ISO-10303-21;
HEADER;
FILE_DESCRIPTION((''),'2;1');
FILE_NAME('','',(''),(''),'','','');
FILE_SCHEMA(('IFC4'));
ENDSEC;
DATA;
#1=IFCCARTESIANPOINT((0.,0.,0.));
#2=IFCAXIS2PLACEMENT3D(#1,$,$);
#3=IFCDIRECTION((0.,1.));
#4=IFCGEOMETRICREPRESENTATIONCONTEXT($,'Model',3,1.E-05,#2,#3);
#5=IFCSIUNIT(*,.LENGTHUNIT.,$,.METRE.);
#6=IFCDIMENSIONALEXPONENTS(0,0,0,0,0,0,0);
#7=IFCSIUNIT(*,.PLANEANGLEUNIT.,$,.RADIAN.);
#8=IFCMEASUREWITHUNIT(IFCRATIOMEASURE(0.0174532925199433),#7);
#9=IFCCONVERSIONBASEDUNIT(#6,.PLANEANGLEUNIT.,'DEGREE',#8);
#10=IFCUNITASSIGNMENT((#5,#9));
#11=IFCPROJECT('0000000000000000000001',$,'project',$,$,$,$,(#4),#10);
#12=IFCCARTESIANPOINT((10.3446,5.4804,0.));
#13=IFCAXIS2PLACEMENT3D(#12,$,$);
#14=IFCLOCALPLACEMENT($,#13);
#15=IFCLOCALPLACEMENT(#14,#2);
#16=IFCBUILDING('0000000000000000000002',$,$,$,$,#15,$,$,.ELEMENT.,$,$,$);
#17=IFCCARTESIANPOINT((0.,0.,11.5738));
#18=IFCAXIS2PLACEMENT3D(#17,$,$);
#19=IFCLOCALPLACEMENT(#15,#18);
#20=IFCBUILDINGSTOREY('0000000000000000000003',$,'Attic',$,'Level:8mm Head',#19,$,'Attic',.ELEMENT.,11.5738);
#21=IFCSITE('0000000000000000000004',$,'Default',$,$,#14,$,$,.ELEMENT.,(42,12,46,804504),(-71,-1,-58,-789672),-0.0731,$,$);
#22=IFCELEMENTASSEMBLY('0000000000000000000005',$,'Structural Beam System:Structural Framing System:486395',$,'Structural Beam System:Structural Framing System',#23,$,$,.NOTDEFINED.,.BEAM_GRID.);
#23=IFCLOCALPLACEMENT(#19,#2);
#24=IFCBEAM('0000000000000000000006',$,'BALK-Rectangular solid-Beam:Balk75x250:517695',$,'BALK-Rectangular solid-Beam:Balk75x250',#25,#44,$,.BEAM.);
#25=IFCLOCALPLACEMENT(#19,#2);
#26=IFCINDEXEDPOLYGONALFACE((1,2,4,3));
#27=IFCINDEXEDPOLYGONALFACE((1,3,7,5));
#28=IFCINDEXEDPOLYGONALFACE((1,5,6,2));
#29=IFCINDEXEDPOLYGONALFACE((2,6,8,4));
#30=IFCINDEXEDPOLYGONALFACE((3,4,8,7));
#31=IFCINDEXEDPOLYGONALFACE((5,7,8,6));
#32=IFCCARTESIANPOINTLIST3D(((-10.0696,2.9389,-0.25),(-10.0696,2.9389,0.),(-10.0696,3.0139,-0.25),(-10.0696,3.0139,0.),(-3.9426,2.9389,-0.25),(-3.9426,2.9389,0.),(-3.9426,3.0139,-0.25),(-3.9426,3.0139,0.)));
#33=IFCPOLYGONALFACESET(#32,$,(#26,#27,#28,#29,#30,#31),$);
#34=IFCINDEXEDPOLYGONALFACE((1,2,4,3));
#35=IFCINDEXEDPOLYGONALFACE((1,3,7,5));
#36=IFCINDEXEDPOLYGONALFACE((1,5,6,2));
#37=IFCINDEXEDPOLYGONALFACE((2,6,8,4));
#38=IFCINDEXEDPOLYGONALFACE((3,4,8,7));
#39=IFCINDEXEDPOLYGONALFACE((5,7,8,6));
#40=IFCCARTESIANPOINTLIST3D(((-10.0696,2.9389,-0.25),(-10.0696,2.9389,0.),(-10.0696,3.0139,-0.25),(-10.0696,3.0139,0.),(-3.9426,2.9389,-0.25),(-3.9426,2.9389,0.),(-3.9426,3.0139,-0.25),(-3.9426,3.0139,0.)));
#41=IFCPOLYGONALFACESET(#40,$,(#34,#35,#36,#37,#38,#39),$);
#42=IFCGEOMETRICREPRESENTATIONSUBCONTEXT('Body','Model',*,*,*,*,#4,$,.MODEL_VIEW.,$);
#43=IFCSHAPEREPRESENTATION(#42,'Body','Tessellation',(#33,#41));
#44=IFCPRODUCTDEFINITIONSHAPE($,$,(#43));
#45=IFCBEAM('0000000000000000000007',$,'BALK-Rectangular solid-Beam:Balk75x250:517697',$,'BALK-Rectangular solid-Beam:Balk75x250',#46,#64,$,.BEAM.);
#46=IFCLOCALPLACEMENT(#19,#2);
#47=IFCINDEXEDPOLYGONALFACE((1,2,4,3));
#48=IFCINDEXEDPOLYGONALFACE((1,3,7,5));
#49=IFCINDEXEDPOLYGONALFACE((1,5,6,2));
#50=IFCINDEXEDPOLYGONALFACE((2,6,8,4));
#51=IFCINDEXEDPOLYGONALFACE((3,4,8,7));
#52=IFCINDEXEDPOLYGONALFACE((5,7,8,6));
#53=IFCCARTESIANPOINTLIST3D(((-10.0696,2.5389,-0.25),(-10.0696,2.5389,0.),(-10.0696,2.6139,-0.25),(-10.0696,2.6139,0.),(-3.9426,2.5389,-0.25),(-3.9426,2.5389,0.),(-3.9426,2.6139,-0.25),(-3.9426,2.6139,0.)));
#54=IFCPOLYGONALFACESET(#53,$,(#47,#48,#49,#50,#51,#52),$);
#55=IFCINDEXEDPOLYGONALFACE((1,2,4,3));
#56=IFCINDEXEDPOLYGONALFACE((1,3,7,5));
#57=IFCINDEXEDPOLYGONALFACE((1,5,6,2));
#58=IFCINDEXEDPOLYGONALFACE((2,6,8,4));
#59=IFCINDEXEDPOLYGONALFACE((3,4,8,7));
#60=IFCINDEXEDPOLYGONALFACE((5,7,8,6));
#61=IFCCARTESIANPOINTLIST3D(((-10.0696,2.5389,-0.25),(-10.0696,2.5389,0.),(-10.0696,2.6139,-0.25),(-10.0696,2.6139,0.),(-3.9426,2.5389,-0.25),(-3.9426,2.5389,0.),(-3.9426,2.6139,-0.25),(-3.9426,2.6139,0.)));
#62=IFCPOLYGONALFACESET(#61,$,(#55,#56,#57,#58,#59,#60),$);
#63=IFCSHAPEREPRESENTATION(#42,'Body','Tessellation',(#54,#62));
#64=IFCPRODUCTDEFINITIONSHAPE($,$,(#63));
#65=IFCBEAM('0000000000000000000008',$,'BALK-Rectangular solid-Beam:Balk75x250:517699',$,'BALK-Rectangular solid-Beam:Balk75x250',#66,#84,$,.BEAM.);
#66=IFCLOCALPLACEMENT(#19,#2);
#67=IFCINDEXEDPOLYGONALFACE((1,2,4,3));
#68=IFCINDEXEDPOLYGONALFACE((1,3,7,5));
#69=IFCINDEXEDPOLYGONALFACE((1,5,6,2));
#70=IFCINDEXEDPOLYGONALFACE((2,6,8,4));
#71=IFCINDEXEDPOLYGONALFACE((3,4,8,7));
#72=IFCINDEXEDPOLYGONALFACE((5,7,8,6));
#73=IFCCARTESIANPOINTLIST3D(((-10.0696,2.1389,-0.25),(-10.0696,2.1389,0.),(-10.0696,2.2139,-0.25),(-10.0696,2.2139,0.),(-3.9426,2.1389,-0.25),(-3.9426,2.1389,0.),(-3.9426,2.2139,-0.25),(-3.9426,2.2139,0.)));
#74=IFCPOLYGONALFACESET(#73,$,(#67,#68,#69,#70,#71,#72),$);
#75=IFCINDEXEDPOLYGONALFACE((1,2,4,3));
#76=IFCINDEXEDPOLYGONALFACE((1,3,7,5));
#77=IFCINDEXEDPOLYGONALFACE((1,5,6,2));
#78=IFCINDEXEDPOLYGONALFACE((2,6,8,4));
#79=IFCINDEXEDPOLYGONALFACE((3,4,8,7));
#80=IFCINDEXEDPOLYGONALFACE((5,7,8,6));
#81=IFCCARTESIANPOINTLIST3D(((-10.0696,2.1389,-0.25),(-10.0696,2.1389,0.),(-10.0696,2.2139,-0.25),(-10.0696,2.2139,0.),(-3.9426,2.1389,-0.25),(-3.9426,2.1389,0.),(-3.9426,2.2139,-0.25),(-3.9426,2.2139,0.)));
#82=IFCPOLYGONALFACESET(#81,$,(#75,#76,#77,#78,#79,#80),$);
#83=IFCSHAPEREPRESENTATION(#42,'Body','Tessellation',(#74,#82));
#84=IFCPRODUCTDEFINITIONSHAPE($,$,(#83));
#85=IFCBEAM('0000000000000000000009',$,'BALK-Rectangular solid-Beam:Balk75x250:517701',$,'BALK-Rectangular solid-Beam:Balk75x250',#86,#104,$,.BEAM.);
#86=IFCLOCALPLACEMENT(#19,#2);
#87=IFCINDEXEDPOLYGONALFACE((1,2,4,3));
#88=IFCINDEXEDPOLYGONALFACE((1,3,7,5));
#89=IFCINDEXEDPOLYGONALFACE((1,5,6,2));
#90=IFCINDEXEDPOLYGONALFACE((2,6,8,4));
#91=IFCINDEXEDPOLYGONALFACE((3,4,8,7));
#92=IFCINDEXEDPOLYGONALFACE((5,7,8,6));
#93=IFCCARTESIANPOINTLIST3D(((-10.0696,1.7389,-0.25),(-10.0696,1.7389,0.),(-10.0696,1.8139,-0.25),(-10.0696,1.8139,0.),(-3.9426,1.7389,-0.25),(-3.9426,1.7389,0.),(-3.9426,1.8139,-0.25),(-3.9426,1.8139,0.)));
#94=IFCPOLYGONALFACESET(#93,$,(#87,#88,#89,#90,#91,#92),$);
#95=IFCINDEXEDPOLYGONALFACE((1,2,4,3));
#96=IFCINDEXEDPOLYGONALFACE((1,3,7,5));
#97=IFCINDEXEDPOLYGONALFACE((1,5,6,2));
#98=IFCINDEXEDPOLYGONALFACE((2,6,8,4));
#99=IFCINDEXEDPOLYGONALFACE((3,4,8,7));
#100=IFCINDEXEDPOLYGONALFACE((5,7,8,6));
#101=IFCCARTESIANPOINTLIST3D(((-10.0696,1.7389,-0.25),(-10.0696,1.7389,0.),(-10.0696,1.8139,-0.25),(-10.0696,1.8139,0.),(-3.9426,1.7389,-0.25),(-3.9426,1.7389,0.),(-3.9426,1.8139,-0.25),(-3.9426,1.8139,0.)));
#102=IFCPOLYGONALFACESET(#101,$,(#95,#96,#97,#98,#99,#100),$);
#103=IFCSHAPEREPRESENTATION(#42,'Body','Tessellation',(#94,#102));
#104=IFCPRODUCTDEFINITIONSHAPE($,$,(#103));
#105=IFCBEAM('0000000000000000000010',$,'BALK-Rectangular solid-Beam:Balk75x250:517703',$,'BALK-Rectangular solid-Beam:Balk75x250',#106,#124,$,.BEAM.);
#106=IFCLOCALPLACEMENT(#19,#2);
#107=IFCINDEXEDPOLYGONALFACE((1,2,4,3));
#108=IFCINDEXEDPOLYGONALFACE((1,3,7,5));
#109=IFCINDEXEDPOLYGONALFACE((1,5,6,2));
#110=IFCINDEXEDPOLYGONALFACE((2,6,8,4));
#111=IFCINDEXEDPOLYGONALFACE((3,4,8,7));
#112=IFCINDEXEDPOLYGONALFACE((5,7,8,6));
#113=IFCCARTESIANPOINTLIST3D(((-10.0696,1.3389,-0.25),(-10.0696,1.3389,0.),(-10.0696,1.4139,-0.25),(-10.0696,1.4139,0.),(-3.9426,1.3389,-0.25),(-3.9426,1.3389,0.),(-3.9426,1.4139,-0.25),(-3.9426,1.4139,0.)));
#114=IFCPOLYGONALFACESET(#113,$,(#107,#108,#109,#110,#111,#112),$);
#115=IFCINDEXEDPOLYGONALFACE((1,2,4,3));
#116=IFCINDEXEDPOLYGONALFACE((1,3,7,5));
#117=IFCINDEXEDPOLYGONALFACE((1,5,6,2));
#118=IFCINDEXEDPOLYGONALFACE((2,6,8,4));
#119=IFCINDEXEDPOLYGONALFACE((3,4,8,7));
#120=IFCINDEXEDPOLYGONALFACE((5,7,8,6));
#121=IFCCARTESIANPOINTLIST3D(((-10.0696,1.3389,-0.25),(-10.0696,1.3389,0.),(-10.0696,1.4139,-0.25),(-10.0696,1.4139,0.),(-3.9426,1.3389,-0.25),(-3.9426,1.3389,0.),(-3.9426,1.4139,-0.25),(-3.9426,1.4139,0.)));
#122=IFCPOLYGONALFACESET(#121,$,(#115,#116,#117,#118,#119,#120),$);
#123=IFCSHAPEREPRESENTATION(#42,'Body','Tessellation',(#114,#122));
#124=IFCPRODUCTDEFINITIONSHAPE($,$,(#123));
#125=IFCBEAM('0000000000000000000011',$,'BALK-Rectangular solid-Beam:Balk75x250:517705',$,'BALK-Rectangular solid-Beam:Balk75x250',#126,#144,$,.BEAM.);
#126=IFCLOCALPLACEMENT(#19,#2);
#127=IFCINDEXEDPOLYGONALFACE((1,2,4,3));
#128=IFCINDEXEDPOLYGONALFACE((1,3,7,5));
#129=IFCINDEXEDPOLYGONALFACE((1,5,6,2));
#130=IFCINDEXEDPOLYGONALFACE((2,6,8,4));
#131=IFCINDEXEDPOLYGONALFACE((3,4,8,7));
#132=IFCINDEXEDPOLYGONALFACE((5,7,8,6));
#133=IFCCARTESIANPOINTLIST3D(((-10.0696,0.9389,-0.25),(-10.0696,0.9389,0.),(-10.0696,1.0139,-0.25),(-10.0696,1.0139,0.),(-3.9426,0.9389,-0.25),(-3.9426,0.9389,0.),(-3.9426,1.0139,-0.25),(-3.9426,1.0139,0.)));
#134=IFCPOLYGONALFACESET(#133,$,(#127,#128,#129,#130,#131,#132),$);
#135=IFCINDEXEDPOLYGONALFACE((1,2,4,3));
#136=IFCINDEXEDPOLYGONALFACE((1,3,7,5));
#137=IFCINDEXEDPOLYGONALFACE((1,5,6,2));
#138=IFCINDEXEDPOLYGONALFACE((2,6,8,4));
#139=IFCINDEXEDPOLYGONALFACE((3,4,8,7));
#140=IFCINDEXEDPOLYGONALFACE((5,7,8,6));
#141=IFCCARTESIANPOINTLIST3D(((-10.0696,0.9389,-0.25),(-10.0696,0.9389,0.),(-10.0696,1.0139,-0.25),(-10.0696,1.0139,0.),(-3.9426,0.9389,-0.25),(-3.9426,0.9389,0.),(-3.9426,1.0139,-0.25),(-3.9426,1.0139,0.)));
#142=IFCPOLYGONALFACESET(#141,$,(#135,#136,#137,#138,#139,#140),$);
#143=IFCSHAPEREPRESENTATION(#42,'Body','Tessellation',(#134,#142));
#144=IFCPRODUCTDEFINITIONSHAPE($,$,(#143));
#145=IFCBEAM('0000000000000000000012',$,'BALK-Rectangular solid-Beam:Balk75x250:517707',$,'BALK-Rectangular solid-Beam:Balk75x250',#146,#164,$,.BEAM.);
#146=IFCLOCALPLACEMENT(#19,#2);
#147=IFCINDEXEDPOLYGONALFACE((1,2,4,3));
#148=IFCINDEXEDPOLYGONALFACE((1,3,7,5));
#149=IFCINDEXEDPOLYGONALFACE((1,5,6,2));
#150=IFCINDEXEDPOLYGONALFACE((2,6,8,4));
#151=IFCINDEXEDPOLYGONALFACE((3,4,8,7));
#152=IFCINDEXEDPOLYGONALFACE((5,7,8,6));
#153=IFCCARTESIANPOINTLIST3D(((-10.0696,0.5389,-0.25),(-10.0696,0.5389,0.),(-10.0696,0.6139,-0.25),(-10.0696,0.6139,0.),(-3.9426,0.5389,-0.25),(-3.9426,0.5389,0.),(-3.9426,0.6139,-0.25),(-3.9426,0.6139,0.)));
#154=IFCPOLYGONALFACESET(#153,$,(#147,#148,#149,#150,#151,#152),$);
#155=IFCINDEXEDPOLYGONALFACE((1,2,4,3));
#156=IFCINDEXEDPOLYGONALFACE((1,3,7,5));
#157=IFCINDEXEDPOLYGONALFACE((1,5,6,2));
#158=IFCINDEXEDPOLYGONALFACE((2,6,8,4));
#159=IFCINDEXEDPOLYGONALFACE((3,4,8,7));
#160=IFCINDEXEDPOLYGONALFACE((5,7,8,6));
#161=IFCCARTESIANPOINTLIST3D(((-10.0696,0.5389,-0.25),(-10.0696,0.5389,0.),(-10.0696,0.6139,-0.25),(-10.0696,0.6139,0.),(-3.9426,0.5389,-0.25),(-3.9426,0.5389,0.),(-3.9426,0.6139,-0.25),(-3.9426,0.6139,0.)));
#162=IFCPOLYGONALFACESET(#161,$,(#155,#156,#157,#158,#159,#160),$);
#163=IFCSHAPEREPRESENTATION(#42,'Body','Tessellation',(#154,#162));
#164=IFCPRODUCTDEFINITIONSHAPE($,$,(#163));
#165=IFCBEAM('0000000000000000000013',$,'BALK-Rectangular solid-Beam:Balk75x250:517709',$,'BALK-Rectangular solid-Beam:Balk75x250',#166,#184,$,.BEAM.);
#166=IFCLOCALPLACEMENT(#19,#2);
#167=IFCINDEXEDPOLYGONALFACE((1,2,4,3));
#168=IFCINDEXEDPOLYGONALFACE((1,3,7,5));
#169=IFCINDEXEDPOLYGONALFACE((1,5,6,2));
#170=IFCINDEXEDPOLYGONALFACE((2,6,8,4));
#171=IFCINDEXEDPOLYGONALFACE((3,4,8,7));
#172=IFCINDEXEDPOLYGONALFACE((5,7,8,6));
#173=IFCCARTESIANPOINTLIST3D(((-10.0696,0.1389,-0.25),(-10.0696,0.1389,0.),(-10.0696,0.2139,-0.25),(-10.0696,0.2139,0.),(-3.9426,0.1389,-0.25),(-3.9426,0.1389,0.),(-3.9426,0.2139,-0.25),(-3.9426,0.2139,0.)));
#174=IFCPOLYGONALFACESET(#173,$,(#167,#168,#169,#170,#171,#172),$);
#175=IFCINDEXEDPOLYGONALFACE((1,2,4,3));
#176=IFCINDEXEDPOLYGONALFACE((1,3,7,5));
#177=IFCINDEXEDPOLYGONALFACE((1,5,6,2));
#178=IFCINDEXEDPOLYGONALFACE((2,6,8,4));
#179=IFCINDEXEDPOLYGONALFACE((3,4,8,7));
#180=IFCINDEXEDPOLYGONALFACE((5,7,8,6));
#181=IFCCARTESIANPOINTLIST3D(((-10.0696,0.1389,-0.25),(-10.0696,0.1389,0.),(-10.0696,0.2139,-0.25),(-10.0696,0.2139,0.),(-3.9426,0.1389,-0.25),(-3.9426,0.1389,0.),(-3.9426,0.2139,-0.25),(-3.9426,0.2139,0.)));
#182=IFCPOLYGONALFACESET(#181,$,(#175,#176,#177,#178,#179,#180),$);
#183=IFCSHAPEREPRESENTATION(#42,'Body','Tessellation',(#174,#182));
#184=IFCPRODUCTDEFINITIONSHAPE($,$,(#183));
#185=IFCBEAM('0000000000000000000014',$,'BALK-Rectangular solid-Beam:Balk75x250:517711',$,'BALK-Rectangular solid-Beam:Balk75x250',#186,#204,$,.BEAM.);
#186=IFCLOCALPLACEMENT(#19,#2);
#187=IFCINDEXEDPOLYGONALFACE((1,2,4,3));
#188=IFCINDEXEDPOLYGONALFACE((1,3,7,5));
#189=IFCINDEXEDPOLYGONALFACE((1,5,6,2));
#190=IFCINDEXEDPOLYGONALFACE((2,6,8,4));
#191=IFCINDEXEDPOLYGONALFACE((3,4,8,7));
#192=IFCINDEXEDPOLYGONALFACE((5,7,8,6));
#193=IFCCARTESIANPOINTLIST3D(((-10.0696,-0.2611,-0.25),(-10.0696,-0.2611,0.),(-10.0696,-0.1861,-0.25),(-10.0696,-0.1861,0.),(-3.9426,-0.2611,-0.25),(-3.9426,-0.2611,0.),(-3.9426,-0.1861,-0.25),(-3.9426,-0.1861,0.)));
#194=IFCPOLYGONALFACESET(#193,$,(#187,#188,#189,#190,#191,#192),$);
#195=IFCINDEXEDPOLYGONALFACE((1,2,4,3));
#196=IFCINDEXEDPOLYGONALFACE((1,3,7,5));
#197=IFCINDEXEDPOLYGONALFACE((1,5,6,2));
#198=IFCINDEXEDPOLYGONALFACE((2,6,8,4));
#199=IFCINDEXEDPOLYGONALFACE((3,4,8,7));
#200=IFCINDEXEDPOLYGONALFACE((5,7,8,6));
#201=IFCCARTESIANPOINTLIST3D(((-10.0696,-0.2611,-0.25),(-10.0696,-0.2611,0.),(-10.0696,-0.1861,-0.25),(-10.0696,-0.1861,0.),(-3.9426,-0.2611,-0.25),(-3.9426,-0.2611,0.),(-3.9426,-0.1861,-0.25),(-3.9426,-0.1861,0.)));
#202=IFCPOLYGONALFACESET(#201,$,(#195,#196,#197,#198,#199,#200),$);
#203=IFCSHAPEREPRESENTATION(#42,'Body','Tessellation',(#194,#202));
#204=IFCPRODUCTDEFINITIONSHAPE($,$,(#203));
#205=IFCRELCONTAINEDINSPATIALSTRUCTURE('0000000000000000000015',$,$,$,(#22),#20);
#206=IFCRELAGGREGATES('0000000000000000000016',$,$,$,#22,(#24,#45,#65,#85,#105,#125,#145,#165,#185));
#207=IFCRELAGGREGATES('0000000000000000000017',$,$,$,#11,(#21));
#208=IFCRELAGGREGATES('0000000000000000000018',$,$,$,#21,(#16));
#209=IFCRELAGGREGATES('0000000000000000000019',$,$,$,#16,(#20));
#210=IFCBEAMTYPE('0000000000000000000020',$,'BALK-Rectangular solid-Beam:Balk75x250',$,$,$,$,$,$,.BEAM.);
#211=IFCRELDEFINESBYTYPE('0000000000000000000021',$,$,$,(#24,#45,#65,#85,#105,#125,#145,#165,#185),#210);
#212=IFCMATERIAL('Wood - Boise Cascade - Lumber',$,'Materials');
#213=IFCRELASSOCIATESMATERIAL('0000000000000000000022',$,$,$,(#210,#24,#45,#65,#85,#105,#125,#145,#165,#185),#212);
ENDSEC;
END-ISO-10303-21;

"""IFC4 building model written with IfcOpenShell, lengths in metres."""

from ifc_helpers import new_model, entity, si_unit, converted_unit, direction, frame, frame_2d, origin, origin_2d_with_axis, place, context, subcontext, project, spatial, rectangle, extrude, source, transform, mapped, material, material_profile, profile_set, profile_usage, type_object, type_shapes, element, aggregate, save


model = new_model("IFC4")

# Units and contexts
model_context = context("Model", 3, precision=1e-05, world=origin(), true_north=direction((0.0, 1.0)))
body_context = subcontext(model_context, "Body", "Model", "MODEL_VIEW")
ifc_project = project(units=[si_unit("LENGTHUNIT", "METRE"), converted_unit("PLANEANGLEUNIT", "DEGREE", entity("IfcRatioMeasure", 0.0174532925199433), si_unit("PLANEANGLEUNIT", "RADIAN"), dimensions=[0, 0, 0, 0, 0, 0, 0])], contexts=[model_context])

# Site, building, storey
site_placement = place(None, frame((10.3446, 5.4804, 0.0)))
site = spatial("IfcSite", under=ifc_project, at=site_placement, Name="Default", CompositionType="ELEMENT", RefLatitude=(42, 12, 46, 804504), RefLongitude=(-71, -1, -58, -789672), RefElevation=-0.0731)
building_placement = place(site_placement, origin())
building = spatial("IfcBuilding", under=site, at=building_placement, CompositionType="ELEMENT")
storey_placement = place(building_placement, frame((0.0, 0.0, 11.5738)))
storey = spatial("IfcBuildingStorey", under=building, at=storey_placement, Name="Attic", ObjectType="Level:8mm Head", LongName="Attic", CompositionType="ELEMENT", Elevation=11.5738)

# Element assembly, beams
ifc_material = material(Name="Wood - Boise Cascade - Lumber", Category="Materials")
ifc_material_profile = material_profile(ifc_material, rectangle(XDim=0.25, YDim=0.075, at=frame_2d((0.0, 0.0), x_axis=(1.0, 0.0))), Name="Balk75x250")
ifc_profile_set = profile_set([ifc_material_profile], Name="Balk75x250")
assembly_1_placement = place(storey_placement, origin())
assembly_1 = element("IfcElementAssembly", 1, at=assembly_1_placement, inside=storey, Name="Structural Beam System:Structural Framing System:486395", ObjectType="Structural Beam System:Structural Framing System", AssemblyPlace="NOTDEFINED", PredefinedType="BEAM_GRID")
ifc_profile_usage_1 = profile_usage(ifc_profile_set, cardinal=8)
beam_type_1 = type_object("IfcBeamType", Name="BALK-Rectangular solid-Beam:Balk75x250", PredefinedType="BEAM", material=ifc_profile_set)
shared_shape_1 = source(origin(), body_context, "Body", "SweptSolid", [
    extrude(rectangle(XDim=0.25, YDim=0.075, at=origin_2d_with_axis()), frame((-2.9698, 0.0, 0.0), z_axis=(1.0, 0.0, 0.0), x_axis=(0.0, 0.0, -1.0)), (0.0, 0.0, 1.0), 6.127),
    extrude(rectangle(XDim=0.25, YDim=0.075, at=origin_2d_with_axis()), frame((-2.9698, 0.0, 0.0), z_axis=(1.0, 0.0, 0.0), x_axis=(0.0, 0.0, -1.0)), (0.0, 0.0, 1.0), 6.127),
])
type_shapes(beam_type_1, [shared_shape_1])
beam_1_placement = place(assembly_1_placement, frame((-7.0999, 2.9764, -0.125)))
beam_1 = element("IfcBeam", 2, at=beam_1_placement, type_object=beam_type_1, material=ifc_profile_usage_1, Name="BALK-Rectangular solid-Beam:Balk75x250:517695", ObjectType="BALK-Rectangular solid-Beam:Balk75x250", PredefinedType="BEAM", context=body_context, shape_type="MappedRepresentation", body=[
    mapped(shared_shape_1, transform((0.0, 0.0, 0.0), scale=1.0)),
])
ifc_profile_usage_2 = profile_usage(ifc_profile_set, cardinal=8)
beam_2_placement = place(assembly_1_placement, frame((-7.0999, 2.5764, -0.125)))
beam_2 = element("IfcBeam", 3, at=beam_2_placement, type_object=beam_type_1, material=ifc_profile_usage_2, Name="BALK-Rectangular solid-Beam:Balk75x250:517697", ObjectType="BALK-Rectangular solid-Beam:Balk75x250", PredefinedType="BEAM", context=body_context, shape_type="MappedRepresentation", body=[
    mapped(shared_shape_1, transform((0.0, 0.0, 0.0), scale=1.0)),
])
ifc_profile_usage_3 = profile_usage(ifc_profile_set, cardinal=8)
beam_3_placement = place(assembly_1_placement, frame((-7.0999, 2.1764, -0.125)))
beam_3 = element("IfcBeam", 4, at=beam_3_placement, type_object=beam_type_1, material=ifc_profile_usage_3, Name="BALK-Rectangular solid-Beam:Balk75x250:517699", ObjectType="BALK-Rectangular solid-Beam:Balk75x250", PredefinedType="BEAM", context=body_context, shape_type="MappedRepresentation", body=[
    mapped(shared_shape_1, transform((0.0, 0.0, 0.0), scale=1.0)),
])
ifc_profile_usage_4 = profile_usage(ifc_profile_set, cardinal=8)
beam_4_placement = place(assembly_1_placement, frame((-7.0999, 1.7764, -0.125)))
beam_4 = element("IfcBeam", 5, at=beam_4_placement, type_object=beam_type_1, material=ifc_profile_usage_4, Name="BALK-Rectangular solid-Beam:Balk75x250:517701", ObjectType="BALK-Rectangular solid-Beam:Balk75x250", PredefinedType="BEAM", context=body_context, shape_type="MappedRepresentation", body=[
    mapped(shared_shape_1, transform((0.0, 0.0, 0.0), scale=1.0)),
])
ifc_profile_usage_5 = profile_usage(ifc_profile_set, cardinal=8)
beam_5_placement = place(assembly_1_placement, frame((-7.0999, 1.3764, -0.125)))
beam_5 = element("IfcBeam", 6, at=beam_5_placement, type_object=beam_type_1, material=ifc_profile_usage_5, Name="BALK-Rectangular solid-Beam:Balk75x250:517703", ObjectType="BALK-Rectangular solid-Beam:Balk75x250", PredefinedType="BEAM", context=body_context, shape_type="MappedRepresentation", body=[
    mapped(shared_shape_1, transform((0.0, 0.0, 0.0), scale=1.0)),
])
ifc_profile_usage_6 = profile_usage(ifc_profile_set, cardinal=8)
beam_6_placement = place(assembly_1_placement, frame((-7.0999, 0.9764, -0.125)))
beam_6 = element("IfcBeam", 7, at=beam_6_placement, type_object=beam_type_1, material=ifc_profile_usage_6, Name="BALK-Rectangular solid-Beam:Balk75x250:517705", ObjectType="BALK-Rectangular solid-Beam:Balk75x250", PredefinedType="BEAM", context=body_context, shape_type="MappedRepresentation", body=[
    mapped(shared_shape_1, transform((0.0, 0.0, 0.0), scale=1.0)),
])
ifc_profile_usage_7 = profile_usage(ifc_profile_set, cardinal=8)
beam_7_placement = place(assembly_1_placement, frame((-7.0999, 0.5764, -0.125)))
beam_7 = element("IfcBeam", 8, at=beam_7_placement, type_object=beam_type_1, material=ifc_profile_usage_7, Name="BALK-Rectangular solid-Beam:Balk75x250:517707", ObjectType="BALK-Rectangular solid-Beam:Balk75x250", PredefinedType="BEAM", context=body_context, shape_type="MappedRepresentation", body=[
    mapped(shared_shape_1, transform((0.0, 0.0, 0.0), scale=1.0)),
])
ifc_profile_usage_8 = profile_usage(ifc_profile_set, cardinal=8)
beam_8_placement = place(assembly_1_placement, frame((-7.0999, 0.1764, -0.125)))
beam_8 = element("IfcBeam", 9, at=beam_8_placement, type_object=beam_type_1, material=ifc_profile_usage_8, Name="BALK-Rectangular solid-Beam:Balk75x250:517709", ObjectType="BALK-Rectangular solid-Beam:Balk75x250", PredefinedType="BEAM", context=body_context, shape_type="MappedRepresentation", body=[
    mapped(shared_shape_1, transform((0.0, 0.0, 0.0), scale=1.0)),
])
ifc_profile_usage_9 = profile_usage(ifc_profile_set, cardinal=8)
beam_9_placement = place(assembly_1_placement, frame((-7.0999, -0.2236, -0.125)))
beam_9 = element("IfcBeam", 10, at=beam_9_placement, type_object=beam_type_1, material=ifc_profile_usage_9, Name="BALK-Rectangular solid-Beam:Balk75x250:517711", ObjectType="BALK-Rectangular solid-Beam:Balk75x250", PredefinedType="BEAM", context=body_context, shape_type="MappedRepresentation", body=[
    mapped(shared_shape_1, transform((0.0, 0.0, 0.0), scale=1.0)),
])
aggregate(assembly_1, [beam_1, beam_2, beam_3, beam_4, beam_5, beam_6, beam_7, beam_8, beam_9])

save(model, "model.ifc")
